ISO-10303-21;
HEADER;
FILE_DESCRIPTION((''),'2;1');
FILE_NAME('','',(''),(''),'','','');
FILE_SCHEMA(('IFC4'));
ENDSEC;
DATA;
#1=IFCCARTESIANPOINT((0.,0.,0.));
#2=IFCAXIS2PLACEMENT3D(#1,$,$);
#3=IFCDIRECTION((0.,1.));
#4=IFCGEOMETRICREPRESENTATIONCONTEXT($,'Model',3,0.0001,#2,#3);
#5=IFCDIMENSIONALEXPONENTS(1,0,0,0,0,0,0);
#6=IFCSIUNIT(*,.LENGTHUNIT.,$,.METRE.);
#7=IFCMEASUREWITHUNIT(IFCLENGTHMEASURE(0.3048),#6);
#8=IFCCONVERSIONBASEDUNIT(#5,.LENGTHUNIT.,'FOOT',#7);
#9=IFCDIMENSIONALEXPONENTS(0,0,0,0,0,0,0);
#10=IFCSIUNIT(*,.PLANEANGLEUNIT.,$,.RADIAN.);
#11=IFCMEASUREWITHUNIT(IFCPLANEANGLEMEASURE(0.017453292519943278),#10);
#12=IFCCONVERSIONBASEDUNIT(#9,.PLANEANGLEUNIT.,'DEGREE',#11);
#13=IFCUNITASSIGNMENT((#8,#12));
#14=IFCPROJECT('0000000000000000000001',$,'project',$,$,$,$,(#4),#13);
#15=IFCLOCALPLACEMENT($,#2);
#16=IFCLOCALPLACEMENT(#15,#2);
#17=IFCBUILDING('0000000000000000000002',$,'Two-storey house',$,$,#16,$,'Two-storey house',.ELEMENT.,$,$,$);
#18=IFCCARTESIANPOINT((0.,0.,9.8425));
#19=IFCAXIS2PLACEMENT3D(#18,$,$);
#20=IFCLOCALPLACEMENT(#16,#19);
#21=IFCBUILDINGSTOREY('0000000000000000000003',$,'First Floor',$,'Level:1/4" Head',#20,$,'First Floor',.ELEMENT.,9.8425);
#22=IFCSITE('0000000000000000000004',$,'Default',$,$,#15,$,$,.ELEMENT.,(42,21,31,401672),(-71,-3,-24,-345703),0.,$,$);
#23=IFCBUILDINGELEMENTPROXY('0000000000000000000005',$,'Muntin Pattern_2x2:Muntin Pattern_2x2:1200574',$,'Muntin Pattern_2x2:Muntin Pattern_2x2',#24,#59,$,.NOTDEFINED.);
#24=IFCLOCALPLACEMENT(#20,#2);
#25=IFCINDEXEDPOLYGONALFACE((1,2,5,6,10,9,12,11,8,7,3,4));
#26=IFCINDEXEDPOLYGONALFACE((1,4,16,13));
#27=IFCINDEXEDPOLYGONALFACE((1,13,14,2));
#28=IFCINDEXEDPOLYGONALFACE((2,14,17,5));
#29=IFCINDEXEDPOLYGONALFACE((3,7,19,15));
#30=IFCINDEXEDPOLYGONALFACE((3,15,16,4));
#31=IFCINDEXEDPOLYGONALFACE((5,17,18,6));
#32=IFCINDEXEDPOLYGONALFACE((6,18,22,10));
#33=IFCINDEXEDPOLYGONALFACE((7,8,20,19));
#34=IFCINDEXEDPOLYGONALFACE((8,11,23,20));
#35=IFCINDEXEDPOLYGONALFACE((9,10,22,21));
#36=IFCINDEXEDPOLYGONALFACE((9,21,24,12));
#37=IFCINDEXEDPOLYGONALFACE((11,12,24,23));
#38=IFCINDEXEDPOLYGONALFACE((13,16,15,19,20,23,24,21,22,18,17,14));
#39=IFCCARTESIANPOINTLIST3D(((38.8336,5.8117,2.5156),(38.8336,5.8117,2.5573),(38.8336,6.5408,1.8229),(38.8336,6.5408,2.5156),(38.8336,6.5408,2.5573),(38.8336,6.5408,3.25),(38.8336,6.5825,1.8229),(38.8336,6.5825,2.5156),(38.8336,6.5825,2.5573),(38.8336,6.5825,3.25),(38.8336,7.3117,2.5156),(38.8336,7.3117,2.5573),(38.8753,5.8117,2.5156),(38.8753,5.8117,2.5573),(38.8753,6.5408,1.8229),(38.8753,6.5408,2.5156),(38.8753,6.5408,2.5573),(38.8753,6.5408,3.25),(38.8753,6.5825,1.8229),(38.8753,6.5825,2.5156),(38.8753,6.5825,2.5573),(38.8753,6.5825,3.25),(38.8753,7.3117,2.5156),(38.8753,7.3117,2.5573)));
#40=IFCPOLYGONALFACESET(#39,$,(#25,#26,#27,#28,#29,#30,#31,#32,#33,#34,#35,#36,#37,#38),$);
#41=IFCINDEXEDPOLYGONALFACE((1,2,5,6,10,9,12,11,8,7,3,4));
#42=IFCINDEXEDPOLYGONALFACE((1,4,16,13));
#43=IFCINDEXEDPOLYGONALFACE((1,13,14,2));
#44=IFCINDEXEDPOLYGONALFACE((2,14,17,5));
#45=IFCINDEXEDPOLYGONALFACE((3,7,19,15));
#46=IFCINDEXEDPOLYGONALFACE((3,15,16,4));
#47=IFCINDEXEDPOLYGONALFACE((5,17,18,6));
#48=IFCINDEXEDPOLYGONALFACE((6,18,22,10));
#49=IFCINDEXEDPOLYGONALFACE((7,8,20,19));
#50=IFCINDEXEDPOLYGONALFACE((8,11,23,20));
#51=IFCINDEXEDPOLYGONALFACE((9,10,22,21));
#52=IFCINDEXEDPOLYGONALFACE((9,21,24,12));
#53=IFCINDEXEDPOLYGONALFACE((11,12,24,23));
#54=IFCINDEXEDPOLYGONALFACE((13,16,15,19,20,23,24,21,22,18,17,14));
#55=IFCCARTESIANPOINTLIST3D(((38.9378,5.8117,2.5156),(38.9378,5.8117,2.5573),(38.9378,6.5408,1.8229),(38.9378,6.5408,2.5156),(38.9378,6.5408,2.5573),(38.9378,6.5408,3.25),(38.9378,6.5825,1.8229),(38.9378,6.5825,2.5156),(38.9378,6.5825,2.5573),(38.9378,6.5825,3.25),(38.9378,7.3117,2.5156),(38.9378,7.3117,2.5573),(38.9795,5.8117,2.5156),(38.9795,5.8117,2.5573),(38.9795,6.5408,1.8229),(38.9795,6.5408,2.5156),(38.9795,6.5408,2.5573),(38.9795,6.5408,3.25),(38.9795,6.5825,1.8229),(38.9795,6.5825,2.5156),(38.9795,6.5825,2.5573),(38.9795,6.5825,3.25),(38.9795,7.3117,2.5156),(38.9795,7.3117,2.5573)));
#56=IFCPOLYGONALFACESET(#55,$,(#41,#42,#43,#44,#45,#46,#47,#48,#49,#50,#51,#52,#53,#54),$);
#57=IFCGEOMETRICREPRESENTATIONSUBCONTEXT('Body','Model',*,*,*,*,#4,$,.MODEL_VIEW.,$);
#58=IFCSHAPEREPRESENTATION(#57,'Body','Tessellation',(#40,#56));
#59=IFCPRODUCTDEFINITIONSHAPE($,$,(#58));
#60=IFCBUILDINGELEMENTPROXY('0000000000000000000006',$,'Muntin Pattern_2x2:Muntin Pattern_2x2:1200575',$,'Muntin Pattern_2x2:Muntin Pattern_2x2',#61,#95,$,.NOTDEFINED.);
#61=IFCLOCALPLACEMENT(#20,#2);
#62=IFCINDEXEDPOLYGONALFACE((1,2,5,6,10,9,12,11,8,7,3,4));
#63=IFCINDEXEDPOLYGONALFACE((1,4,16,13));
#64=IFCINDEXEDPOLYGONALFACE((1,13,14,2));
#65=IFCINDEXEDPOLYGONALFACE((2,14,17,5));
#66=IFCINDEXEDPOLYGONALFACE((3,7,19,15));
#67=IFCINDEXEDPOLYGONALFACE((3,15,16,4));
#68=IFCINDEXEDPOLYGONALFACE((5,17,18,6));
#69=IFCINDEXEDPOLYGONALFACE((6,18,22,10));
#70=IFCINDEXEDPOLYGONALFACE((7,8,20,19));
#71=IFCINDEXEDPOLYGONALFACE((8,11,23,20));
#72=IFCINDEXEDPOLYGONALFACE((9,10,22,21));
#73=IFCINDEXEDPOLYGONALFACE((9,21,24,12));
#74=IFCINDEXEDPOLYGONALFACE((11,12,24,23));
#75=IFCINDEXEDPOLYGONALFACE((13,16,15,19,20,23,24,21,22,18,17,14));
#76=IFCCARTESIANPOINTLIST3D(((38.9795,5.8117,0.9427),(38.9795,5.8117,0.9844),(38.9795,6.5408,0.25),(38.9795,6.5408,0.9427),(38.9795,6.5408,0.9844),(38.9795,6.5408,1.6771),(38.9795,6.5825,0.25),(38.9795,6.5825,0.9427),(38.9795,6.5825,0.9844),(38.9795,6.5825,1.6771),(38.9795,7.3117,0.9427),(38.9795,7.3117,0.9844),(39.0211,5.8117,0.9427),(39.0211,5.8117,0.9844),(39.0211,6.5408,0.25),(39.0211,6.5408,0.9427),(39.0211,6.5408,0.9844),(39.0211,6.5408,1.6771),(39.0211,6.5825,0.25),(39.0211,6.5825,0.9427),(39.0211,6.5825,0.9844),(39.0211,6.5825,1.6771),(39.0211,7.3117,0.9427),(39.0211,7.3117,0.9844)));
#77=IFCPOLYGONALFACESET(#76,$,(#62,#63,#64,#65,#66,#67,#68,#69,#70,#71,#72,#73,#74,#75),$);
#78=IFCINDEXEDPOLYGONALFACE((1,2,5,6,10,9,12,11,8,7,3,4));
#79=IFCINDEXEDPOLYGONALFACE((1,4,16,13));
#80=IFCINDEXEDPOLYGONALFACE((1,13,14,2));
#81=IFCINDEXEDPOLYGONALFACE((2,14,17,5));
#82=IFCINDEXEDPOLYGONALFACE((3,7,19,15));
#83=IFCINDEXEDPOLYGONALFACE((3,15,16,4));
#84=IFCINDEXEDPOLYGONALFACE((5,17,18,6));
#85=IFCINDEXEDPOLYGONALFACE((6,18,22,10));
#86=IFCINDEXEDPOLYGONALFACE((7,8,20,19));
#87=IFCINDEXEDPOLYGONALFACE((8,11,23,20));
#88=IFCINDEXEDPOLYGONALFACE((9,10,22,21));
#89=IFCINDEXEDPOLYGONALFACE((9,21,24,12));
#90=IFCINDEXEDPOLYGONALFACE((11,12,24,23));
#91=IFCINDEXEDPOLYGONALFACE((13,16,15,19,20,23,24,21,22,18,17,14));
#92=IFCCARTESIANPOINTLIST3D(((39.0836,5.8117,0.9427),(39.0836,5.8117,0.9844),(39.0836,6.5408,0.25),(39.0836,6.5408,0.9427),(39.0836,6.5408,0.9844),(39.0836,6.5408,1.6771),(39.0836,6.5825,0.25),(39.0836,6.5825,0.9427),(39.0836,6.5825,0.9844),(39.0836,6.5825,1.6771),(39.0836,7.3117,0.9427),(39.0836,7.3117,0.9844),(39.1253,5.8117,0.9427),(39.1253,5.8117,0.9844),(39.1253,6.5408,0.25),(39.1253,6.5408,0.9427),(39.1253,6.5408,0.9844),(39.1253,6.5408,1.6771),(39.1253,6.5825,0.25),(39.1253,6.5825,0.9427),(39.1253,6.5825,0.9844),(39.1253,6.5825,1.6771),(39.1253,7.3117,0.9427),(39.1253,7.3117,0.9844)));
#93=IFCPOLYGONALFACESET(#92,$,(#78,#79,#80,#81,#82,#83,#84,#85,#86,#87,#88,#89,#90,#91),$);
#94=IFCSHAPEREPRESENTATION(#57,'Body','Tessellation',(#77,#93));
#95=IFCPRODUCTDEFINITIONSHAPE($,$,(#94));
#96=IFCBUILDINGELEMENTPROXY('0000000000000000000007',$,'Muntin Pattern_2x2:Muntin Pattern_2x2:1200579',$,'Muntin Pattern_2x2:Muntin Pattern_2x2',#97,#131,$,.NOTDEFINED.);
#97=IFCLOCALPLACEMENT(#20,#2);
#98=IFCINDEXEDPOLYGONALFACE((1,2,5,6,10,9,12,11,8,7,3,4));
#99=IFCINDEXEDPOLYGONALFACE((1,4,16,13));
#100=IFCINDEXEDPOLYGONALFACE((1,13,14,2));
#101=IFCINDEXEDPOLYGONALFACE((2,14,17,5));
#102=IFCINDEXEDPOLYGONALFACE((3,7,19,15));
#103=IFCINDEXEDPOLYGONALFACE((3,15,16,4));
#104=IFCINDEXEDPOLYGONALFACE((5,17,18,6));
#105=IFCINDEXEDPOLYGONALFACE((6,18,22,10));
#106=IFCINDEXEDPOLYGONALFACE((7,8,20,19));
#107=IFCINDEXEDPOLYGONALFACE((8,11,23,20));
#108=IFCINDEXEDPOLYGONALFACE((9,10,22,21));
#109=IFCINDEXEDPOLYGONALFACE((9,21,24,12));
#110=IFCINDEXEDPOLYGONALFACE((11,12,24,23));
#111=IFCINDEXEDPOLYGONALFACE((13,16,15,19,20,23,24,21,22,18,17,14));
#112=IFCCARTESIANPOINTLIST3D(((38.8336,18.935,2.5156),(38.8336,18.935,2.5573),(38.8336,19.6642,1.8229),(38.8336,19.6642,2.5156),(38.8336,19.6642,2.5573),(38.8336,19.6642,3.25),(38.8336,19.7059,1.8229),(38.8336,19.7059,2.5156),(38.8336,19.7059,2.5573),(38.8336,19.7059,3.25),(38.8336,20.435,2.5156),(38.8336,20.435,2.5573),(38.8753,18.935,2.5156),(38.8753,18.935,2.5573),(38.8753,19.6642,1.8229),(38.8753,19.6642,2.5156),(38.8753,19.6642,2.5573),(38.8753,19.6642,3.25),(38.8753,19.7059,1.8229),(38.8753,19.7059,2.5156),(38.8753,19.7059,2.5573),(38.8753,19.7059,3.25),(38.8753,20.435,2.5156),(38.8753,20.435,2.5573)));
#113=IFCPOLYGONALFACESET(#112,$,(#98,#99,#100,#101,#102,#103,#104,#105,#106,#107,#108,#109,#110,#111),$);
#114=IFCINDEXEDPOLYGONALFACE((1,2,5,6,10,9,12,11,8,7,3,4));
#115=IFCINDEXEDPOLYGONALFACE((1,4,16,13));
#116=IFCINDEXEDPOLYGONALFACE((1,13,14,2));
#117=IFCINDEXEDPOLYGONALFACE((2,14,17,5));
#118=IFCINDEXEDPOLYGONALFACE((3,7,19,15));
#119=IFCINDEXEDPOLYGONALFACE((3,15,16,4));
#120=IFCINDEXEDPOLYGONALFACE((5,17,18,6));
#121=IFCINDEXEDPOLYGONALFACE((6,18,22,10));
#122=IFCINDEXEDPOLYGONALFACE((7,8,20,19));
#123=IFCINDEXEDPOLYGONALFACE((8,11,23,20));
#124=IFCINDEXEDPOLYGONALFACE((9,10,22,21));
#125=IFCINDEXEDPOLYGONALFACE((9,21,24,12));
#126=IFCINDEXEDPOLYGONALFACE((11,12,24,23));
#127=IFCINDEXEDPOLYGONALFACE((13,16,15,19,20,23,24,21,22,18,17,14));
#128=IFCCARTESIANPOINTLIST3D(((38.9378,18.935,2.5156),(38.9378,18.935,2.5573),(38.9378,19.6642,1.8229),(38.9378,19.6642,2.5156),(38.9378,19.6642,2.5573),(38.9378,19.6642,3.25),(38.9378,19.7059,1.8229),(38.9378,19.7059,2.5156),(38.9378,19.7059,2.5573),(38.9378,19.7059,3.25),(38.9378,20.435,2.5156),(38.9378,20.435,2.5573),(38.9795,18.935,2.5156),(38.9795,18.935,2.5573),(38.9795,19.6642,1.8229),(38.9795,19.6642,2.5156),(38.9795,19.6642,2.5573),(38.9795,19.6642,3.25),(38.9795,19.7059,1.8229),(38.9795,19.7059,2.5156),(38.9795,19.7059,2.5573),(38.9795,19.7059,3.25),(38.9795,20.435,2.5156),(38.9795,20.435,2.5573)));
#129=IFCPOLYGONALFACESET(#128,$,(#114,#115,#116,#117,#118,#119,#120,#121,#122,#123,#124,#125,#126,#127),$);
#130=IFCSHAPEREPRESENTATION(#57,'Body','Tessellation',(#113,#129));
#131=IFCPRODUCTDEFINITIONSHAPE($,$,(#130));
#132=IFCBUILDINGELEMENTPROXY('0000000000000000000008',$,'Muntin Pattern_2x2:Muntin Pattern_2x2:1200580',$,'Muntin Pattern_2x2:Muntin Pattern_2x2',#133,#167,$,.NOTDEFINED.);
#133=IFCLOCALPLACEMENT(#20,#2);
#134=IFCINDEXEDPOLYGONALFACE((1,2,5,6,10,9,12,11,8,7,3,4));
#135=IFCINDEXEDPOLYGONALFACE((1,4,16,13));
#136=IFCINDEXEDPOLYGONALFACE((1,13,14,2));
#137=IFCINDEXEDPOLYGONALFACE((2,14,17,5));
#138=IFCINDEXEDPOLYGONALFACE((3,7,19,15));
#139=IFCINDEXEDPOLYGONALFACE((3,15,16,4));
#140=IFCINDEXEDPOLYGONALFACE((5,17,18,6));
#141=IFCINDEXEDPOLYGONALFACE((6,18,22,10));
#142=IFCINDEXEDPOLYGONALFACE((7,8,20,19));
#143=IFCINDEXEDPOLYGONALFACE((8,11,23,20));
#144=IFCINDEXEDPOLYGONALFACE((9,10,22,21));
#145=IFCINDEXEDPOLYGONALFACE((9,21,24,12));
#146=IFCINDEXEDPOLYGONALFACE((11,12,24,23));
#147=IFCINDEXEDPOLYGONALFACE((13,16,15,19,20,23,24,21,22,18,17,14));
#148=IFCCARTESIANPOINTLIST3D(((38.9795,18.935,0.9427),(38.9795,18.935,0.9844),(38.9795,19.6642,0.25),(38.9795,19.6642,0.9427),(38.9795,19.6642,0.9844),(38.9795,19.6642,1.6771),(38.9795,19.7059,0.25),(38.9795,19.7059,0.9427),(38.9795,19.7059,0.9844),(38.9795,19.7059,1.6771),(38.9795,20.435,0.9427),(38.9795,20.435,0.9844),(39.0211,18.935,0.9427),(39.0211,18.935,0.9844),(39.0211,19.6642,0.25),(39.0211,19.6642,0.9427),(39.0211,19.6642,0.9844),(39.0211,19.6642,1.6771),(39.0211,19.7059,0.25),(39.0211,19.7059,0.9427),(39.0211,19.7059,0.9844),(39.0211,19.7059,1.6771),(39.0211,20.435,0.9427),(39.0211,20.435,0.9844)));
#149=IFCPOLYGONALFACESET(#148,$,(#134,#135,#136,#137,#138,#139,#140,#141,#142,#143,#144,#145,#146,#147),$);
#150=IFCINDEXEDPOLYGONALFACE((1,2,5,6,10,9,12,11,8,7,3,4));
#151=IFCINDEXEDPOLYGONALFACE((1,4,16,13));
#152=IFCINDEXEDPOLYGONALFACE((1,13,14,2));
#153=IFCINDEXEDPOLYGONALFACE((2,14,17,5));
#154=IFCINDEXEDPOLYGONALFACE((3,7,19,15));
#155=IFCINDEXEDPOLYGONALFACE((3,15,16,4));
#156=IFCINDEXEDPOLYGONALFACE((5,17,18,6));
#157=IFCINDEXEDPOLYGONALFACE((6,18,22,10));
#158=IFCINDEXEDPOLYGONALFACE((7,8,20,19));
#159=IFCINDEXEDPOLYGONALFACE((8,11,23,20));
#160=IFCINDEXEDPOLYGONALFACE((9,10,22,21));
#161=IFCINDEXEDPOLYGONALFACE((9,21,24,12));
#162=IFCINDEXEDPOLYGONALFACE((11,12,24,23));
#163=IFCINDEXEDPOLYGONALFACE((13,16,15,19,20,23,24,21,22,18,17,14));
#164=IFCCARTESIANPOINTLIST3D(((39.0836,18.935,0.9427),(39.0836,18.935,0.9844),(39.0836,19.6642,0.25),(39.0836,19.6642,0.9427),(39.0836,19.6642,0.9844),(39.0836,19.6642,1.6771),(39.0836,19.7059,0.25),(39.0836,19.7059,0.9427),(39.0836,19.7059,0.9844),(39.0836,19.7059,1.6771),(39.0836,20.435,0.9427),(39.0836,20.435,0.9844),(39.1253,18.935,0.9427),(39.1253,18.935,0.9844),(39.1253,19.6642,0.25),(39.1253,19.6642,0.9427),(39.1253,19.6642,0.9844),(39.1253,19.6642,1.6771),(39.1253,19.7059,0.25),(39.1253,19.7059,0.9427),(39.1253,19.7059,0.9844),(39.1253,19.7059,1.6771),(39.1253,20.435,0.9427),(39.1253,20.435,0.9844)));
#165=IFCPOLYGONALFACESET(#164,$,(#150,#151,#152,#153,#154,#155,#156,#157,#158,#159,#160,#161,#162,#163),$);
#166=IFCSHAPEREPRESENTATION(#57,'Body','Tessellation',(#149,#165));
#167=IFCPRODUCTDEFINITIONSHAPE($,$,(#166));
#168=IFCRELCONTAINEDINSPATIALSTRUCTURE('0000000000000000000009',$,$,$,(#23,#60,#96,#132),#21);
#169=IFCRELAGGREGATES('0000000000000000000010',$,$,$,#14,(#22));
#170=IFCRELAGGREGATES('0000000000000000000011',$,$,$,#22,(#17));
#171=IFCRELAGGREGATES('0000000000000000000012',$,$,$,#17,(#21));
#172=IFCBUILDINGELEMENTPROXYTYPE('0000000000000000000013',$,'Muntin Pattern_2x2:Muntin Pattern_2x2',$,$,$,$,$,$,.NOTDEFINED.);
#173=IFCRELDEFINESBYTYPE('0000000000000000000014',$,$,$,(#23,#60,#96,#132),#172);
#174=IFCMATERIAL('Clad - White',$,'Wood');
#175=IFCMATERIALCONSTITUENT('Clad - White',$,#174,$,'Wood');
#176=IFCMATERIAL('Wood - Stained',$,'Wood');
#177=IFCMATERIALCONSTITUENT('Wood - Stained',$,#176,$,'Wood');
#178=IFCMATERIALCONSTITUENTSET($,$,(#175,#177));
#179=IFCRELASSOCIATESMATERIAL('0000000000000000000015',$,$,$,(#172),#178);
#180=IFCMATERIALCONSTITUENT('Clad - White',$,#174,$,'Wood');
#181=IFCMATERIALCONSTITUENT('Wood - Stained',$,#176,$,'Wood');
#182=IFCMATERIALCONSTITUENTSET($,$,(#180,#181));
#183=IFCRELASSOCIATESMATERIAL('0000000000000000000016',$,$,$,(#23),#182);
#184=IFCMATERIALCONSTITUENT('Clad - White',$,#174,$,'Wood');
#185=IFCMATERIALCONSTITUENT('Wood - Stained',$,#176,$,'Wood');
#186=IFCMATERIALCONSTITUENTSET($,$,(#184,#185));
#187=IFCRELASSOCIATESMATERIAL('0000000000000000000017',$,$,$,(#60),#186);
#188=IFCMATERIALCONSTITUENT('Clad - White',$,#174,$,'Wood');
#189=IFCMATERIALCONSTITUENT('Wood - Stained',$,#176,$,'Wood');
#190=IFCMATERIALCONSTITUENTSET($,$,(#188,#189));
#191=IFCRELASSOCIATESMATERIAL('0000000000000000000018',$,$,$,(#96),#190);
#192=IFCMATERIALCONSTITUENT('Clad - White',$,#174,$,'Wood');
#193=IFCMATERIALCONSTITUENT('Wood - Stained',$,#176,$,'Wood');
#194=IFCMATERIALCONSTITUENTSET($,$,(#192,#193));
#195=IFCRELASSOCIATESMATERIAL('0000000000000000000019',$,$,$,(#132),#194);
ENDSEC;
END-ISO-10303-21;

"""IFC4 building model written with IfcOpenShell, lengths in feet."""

from ifc_helpers import new_model, entity, si_unit, converted_unit, direction, frame, origin, place, context, subcontext, project, spatial, indexed_curve, outline, extrude, source, transform, mapped, material, constituent, constituent_set, type_object, type_shapes, element, save


model = new_model("IFC4")

# Units and contexts
model_context = context("Model", 3, precision=0.0001, world=origin(), true_north=direction((0.0, 1.0)))
body_context = subcontext(model_context, "Body", "Model", "MODEL_VIEW")
ifc_project = project(units=[converted_unit("LENGTHUNIT", "FOOT", entity("IfcLengthMeasure", 0.3048), si_unit("LENGTHUNIT", "METRE"), dimensions=[1, 0, 0, 0, 0, 0, 0]), converted_unit("PLANEANGLEUNIT", "DEGREE", entity("IfcPlaneAngleMeasure", 0.017453292519943278), si_unit("PLANEANGLEUNIT", "RADIAN"), dimensions=[0, 0, 0, 0, 0, 0, 0])], contexts=[model_context])

# Site, building, storey
site_placement = place(None, origin())
site = spatial("IfcSite", under=ifc_project, at=site_placement, Name="Default", CompositionType="ELEMENT", RefLatitude=(42, 21, 31, 401672), RefLongitude=(-71, -3, -24, -345703), RefElevation=0.0)
building_placement = place(site_placement, origin())
building = spatial("IfcBuilding", under=site, at=building_placement, Name="Two-storey house", LongName="Two-storey house", CompositionType="ELEMENT")
storey_placement = place(building_placement, frame((0.0, 0.0, 9.8425)))
storey = spatial("IfcBuildingStorey", under=building, at=storey_placement, Name="First Floor", ObjectType="Level:1/4\" Head", LongName="First Floor", CompositionType="ELEMENT", Elevation=9.8425)

# Shared definitions
ifc_material_1 = material(Name="Wood - Stained", Category="Wood")

# Building element proxies
ifc_material_2 = material(Name="Clad - White", Category="Wood")
ifc_constituent_1 = constituent(ifc_material_2, Name="Clad - White", Category="Wood")
ifc_constituent_2 = constituent(ifc_material_1, Name="Wood - Stained", Category="Wood")
ifc_constituent_set_1 = constituent_set(constituents=[ifc_constituent_1, ifc_constituent_2])
ifc_constituent_3 = constituent(ifc_material_2, Name="Clad - White", Category="Wood")
ifc_constituent_4 = constituent(ifc_material_1, Name="Wood - Stained", Category="Wood")
ifc_constituent_set_2 = constituent_set(constituents=[ifc_constituent_3, ifc_constituent_4])
building_element_proxy_type_1 = type_object("IfcBuildingElementProxyType", Name="Muntin Pattern_2x2:Muntin Pattern_2x2", PredefinedType="NOTDEFINED", material=ifc_constituent_set_2)
shared_shape_1 = source(origin(), body_context, "Body", "SweptSolid", [
    extrude(outline(indexed_curve([(0.0208, -0.0208), (0.7135, -0.0208), (0.7135, 0.0208), (0.0208, 0.0208), (0.0208, 0.75), (-0.0208, 0.75), (-0.0208, 0.0208), (-0.7135, 0.0208), (-0.7135, -0.0208), (-0.0208, -0.0208), (-0.0208, -0.75), (0.0208, -0.75), (0.0208, -0.0208)], self_intersect=False)), frame((0.0, 0.0312, 0.7135), z_axis=(0.0, 1.0, 0.0), x_axis=(0.0, 0.0, 1.0)), (0.0, 0.0, 1.0), 0.0417),
    extrude(outline(indexed_curve([(0.0208, -0.0208), (0.7135, -0.0208), (0.7135, 0.0208), (0.0208, 0.0208), (0.0208, 0.75), (-0.0208, 0.75), (-0.0208, 0.0208), (-0.7135, 0.0208), (-0.7135, -0.0208), (-0.0208, -0.0208), (-0.0208, -0.75), (0.0208, -0.75), (0.0208, -0.0208)], self_intersect=False)), frame((0.0, -0.0729, 0.7135), z_axis=(0.0, 1.0, 0.0), x_axis=(0.0, 0.0, 1.0)), (0.0, 0.0, 1.0), 0.0417),
])
type_shapes(building_element_proxy_type_1, [shared_shape_1])
proxy_1_placement = place(storey_placement, frame((38.9065, 6.5617, 1.8229), z_axis=(0.0, 0.0, 1.0), x_axis=(0.0, 1.0, 0.0)))
element("IfcBuildingElementProxy", 1, at=proxy_1_placement, inside=storey, type_object=building_element_proxy_type_1, material=ifc_constituent_set_1, Name="Muntin Pattern_2x2:Muntin Pattern_2x2:1200574", ObjectType="Muntin Pattern_2x2:Muntin Pattern_2x2", PredefinedType="NOTDEFINED", context=body_context, shape_type="MappedRepresentation", body=[
    mapped(shared_shape_1, transform((0.0, 0.0, 0.0), scale=1.0)),
])
ifc_constituent_5 = constituent(ifc_material_2, Name="Clad - White", Category="Wood")
ifc_constituent_6 = constituent(ifc_material_1, Name="Wood - Stained", Category="Wood")
ifc_constituent_set_3 = constituent_set(constituents=[ifc_constituent_5, ifc_constituent_6])
proxy_2_placement = place(storey_placement, frame((39.0524, 6.5617, 0.25), z_axis=(0.0, 0.0, 1.0), x_axis=(0.0, 1.0, 0.0)))
element("IfcBuildingElementProxy", 2, at=proxy_2_placement, inside=storey, type_object=building_element_proxy_type_1, material=ifc_constituent_set_3, Name="Muntin Pattern_2x2:Muntin Pattern_2x2:1200575", ObjectType="Muntin Pattern_2x2:Muntin Pattern_2x2", PredefinedType="NOTDEFINED", context=body_context, shape_type="MappedRepresentation", body=[
    mapped(shared_shape_1, transform((0.0, 0.0, 0.0), scale=1.0)),
])
ifc_constituent_7 = constituent(ifc_material_2, Name="Clad - White", Category="Wood")
ifc_constituent_8 = constituent(ifc_material_1, Name="Wood - Stained", Category="Wood")
ifc_constituent_set_4 = constituent_set(constituents=[ifc_constituent_7, ifc_constituent_8])
proxy_3_placement = place(storey_placement, frame((38.9065, 19.685, 1.8229), z_axis=(0.0, 0.0, 1.0), x_axis=(0.0, 1.0, 0.0)))
element("IfcBuildingElementProxy", 3, at=proxy_3_placement, inside=storey, type_object=building_element_proxy_type_1, material=ifc_constituent_set_4, Name="Muntin Pattern_2x2:Muntin Pattern_2x2:1200579", ObjectType="Muntin Pattern_2x2:Muntin Pattern_2x2", PredefinedType="NOTDEFINED", context=body_context, shape_type="MappedRepresentation", body=[
    mapped(shared_shape_1, transform((0.0, 0.0, 0.0), scale=1.0)),
])
ifc_constituent_9 = constituent(ifc_material_2, Name="Clad - White", Category="Wood")
ifc_constituent_10 = constituent(ifc_material_1, Name="Wood - Stained", Category="Wood")
ifc_constituent_set_5 = constituent_set(constituents=[ifc_constituent_9, ifc_constituent_10])
proxy_4_placement = place(storey_placement, frame((39.0524, 19.685, 0.25), z_axis=(0.0, 0.0, 1.0), x_axis=(0.0, 1.0, 0.0)))
element("IfcBuildingElementProxy", 4, at=proxy_4_placement, inside=storey, type_object=building_element_proxy_type_1, material=ifc_constituent_set_5, Name="Muntin Pattern_2x2:Muntin Pattern_2x2:1200580", ObjectType="Muntin Pattern_2x2:Muntin Pattern_2x2", PredefinedType="NOTDEFINED", context=body_context, shape_type="MappedRepresentation", body=[
    mapped(shared_shape_1, transform((0.0, 0.0, 0.0), scale=1.0)),
])

save(model, "model.ifc")
